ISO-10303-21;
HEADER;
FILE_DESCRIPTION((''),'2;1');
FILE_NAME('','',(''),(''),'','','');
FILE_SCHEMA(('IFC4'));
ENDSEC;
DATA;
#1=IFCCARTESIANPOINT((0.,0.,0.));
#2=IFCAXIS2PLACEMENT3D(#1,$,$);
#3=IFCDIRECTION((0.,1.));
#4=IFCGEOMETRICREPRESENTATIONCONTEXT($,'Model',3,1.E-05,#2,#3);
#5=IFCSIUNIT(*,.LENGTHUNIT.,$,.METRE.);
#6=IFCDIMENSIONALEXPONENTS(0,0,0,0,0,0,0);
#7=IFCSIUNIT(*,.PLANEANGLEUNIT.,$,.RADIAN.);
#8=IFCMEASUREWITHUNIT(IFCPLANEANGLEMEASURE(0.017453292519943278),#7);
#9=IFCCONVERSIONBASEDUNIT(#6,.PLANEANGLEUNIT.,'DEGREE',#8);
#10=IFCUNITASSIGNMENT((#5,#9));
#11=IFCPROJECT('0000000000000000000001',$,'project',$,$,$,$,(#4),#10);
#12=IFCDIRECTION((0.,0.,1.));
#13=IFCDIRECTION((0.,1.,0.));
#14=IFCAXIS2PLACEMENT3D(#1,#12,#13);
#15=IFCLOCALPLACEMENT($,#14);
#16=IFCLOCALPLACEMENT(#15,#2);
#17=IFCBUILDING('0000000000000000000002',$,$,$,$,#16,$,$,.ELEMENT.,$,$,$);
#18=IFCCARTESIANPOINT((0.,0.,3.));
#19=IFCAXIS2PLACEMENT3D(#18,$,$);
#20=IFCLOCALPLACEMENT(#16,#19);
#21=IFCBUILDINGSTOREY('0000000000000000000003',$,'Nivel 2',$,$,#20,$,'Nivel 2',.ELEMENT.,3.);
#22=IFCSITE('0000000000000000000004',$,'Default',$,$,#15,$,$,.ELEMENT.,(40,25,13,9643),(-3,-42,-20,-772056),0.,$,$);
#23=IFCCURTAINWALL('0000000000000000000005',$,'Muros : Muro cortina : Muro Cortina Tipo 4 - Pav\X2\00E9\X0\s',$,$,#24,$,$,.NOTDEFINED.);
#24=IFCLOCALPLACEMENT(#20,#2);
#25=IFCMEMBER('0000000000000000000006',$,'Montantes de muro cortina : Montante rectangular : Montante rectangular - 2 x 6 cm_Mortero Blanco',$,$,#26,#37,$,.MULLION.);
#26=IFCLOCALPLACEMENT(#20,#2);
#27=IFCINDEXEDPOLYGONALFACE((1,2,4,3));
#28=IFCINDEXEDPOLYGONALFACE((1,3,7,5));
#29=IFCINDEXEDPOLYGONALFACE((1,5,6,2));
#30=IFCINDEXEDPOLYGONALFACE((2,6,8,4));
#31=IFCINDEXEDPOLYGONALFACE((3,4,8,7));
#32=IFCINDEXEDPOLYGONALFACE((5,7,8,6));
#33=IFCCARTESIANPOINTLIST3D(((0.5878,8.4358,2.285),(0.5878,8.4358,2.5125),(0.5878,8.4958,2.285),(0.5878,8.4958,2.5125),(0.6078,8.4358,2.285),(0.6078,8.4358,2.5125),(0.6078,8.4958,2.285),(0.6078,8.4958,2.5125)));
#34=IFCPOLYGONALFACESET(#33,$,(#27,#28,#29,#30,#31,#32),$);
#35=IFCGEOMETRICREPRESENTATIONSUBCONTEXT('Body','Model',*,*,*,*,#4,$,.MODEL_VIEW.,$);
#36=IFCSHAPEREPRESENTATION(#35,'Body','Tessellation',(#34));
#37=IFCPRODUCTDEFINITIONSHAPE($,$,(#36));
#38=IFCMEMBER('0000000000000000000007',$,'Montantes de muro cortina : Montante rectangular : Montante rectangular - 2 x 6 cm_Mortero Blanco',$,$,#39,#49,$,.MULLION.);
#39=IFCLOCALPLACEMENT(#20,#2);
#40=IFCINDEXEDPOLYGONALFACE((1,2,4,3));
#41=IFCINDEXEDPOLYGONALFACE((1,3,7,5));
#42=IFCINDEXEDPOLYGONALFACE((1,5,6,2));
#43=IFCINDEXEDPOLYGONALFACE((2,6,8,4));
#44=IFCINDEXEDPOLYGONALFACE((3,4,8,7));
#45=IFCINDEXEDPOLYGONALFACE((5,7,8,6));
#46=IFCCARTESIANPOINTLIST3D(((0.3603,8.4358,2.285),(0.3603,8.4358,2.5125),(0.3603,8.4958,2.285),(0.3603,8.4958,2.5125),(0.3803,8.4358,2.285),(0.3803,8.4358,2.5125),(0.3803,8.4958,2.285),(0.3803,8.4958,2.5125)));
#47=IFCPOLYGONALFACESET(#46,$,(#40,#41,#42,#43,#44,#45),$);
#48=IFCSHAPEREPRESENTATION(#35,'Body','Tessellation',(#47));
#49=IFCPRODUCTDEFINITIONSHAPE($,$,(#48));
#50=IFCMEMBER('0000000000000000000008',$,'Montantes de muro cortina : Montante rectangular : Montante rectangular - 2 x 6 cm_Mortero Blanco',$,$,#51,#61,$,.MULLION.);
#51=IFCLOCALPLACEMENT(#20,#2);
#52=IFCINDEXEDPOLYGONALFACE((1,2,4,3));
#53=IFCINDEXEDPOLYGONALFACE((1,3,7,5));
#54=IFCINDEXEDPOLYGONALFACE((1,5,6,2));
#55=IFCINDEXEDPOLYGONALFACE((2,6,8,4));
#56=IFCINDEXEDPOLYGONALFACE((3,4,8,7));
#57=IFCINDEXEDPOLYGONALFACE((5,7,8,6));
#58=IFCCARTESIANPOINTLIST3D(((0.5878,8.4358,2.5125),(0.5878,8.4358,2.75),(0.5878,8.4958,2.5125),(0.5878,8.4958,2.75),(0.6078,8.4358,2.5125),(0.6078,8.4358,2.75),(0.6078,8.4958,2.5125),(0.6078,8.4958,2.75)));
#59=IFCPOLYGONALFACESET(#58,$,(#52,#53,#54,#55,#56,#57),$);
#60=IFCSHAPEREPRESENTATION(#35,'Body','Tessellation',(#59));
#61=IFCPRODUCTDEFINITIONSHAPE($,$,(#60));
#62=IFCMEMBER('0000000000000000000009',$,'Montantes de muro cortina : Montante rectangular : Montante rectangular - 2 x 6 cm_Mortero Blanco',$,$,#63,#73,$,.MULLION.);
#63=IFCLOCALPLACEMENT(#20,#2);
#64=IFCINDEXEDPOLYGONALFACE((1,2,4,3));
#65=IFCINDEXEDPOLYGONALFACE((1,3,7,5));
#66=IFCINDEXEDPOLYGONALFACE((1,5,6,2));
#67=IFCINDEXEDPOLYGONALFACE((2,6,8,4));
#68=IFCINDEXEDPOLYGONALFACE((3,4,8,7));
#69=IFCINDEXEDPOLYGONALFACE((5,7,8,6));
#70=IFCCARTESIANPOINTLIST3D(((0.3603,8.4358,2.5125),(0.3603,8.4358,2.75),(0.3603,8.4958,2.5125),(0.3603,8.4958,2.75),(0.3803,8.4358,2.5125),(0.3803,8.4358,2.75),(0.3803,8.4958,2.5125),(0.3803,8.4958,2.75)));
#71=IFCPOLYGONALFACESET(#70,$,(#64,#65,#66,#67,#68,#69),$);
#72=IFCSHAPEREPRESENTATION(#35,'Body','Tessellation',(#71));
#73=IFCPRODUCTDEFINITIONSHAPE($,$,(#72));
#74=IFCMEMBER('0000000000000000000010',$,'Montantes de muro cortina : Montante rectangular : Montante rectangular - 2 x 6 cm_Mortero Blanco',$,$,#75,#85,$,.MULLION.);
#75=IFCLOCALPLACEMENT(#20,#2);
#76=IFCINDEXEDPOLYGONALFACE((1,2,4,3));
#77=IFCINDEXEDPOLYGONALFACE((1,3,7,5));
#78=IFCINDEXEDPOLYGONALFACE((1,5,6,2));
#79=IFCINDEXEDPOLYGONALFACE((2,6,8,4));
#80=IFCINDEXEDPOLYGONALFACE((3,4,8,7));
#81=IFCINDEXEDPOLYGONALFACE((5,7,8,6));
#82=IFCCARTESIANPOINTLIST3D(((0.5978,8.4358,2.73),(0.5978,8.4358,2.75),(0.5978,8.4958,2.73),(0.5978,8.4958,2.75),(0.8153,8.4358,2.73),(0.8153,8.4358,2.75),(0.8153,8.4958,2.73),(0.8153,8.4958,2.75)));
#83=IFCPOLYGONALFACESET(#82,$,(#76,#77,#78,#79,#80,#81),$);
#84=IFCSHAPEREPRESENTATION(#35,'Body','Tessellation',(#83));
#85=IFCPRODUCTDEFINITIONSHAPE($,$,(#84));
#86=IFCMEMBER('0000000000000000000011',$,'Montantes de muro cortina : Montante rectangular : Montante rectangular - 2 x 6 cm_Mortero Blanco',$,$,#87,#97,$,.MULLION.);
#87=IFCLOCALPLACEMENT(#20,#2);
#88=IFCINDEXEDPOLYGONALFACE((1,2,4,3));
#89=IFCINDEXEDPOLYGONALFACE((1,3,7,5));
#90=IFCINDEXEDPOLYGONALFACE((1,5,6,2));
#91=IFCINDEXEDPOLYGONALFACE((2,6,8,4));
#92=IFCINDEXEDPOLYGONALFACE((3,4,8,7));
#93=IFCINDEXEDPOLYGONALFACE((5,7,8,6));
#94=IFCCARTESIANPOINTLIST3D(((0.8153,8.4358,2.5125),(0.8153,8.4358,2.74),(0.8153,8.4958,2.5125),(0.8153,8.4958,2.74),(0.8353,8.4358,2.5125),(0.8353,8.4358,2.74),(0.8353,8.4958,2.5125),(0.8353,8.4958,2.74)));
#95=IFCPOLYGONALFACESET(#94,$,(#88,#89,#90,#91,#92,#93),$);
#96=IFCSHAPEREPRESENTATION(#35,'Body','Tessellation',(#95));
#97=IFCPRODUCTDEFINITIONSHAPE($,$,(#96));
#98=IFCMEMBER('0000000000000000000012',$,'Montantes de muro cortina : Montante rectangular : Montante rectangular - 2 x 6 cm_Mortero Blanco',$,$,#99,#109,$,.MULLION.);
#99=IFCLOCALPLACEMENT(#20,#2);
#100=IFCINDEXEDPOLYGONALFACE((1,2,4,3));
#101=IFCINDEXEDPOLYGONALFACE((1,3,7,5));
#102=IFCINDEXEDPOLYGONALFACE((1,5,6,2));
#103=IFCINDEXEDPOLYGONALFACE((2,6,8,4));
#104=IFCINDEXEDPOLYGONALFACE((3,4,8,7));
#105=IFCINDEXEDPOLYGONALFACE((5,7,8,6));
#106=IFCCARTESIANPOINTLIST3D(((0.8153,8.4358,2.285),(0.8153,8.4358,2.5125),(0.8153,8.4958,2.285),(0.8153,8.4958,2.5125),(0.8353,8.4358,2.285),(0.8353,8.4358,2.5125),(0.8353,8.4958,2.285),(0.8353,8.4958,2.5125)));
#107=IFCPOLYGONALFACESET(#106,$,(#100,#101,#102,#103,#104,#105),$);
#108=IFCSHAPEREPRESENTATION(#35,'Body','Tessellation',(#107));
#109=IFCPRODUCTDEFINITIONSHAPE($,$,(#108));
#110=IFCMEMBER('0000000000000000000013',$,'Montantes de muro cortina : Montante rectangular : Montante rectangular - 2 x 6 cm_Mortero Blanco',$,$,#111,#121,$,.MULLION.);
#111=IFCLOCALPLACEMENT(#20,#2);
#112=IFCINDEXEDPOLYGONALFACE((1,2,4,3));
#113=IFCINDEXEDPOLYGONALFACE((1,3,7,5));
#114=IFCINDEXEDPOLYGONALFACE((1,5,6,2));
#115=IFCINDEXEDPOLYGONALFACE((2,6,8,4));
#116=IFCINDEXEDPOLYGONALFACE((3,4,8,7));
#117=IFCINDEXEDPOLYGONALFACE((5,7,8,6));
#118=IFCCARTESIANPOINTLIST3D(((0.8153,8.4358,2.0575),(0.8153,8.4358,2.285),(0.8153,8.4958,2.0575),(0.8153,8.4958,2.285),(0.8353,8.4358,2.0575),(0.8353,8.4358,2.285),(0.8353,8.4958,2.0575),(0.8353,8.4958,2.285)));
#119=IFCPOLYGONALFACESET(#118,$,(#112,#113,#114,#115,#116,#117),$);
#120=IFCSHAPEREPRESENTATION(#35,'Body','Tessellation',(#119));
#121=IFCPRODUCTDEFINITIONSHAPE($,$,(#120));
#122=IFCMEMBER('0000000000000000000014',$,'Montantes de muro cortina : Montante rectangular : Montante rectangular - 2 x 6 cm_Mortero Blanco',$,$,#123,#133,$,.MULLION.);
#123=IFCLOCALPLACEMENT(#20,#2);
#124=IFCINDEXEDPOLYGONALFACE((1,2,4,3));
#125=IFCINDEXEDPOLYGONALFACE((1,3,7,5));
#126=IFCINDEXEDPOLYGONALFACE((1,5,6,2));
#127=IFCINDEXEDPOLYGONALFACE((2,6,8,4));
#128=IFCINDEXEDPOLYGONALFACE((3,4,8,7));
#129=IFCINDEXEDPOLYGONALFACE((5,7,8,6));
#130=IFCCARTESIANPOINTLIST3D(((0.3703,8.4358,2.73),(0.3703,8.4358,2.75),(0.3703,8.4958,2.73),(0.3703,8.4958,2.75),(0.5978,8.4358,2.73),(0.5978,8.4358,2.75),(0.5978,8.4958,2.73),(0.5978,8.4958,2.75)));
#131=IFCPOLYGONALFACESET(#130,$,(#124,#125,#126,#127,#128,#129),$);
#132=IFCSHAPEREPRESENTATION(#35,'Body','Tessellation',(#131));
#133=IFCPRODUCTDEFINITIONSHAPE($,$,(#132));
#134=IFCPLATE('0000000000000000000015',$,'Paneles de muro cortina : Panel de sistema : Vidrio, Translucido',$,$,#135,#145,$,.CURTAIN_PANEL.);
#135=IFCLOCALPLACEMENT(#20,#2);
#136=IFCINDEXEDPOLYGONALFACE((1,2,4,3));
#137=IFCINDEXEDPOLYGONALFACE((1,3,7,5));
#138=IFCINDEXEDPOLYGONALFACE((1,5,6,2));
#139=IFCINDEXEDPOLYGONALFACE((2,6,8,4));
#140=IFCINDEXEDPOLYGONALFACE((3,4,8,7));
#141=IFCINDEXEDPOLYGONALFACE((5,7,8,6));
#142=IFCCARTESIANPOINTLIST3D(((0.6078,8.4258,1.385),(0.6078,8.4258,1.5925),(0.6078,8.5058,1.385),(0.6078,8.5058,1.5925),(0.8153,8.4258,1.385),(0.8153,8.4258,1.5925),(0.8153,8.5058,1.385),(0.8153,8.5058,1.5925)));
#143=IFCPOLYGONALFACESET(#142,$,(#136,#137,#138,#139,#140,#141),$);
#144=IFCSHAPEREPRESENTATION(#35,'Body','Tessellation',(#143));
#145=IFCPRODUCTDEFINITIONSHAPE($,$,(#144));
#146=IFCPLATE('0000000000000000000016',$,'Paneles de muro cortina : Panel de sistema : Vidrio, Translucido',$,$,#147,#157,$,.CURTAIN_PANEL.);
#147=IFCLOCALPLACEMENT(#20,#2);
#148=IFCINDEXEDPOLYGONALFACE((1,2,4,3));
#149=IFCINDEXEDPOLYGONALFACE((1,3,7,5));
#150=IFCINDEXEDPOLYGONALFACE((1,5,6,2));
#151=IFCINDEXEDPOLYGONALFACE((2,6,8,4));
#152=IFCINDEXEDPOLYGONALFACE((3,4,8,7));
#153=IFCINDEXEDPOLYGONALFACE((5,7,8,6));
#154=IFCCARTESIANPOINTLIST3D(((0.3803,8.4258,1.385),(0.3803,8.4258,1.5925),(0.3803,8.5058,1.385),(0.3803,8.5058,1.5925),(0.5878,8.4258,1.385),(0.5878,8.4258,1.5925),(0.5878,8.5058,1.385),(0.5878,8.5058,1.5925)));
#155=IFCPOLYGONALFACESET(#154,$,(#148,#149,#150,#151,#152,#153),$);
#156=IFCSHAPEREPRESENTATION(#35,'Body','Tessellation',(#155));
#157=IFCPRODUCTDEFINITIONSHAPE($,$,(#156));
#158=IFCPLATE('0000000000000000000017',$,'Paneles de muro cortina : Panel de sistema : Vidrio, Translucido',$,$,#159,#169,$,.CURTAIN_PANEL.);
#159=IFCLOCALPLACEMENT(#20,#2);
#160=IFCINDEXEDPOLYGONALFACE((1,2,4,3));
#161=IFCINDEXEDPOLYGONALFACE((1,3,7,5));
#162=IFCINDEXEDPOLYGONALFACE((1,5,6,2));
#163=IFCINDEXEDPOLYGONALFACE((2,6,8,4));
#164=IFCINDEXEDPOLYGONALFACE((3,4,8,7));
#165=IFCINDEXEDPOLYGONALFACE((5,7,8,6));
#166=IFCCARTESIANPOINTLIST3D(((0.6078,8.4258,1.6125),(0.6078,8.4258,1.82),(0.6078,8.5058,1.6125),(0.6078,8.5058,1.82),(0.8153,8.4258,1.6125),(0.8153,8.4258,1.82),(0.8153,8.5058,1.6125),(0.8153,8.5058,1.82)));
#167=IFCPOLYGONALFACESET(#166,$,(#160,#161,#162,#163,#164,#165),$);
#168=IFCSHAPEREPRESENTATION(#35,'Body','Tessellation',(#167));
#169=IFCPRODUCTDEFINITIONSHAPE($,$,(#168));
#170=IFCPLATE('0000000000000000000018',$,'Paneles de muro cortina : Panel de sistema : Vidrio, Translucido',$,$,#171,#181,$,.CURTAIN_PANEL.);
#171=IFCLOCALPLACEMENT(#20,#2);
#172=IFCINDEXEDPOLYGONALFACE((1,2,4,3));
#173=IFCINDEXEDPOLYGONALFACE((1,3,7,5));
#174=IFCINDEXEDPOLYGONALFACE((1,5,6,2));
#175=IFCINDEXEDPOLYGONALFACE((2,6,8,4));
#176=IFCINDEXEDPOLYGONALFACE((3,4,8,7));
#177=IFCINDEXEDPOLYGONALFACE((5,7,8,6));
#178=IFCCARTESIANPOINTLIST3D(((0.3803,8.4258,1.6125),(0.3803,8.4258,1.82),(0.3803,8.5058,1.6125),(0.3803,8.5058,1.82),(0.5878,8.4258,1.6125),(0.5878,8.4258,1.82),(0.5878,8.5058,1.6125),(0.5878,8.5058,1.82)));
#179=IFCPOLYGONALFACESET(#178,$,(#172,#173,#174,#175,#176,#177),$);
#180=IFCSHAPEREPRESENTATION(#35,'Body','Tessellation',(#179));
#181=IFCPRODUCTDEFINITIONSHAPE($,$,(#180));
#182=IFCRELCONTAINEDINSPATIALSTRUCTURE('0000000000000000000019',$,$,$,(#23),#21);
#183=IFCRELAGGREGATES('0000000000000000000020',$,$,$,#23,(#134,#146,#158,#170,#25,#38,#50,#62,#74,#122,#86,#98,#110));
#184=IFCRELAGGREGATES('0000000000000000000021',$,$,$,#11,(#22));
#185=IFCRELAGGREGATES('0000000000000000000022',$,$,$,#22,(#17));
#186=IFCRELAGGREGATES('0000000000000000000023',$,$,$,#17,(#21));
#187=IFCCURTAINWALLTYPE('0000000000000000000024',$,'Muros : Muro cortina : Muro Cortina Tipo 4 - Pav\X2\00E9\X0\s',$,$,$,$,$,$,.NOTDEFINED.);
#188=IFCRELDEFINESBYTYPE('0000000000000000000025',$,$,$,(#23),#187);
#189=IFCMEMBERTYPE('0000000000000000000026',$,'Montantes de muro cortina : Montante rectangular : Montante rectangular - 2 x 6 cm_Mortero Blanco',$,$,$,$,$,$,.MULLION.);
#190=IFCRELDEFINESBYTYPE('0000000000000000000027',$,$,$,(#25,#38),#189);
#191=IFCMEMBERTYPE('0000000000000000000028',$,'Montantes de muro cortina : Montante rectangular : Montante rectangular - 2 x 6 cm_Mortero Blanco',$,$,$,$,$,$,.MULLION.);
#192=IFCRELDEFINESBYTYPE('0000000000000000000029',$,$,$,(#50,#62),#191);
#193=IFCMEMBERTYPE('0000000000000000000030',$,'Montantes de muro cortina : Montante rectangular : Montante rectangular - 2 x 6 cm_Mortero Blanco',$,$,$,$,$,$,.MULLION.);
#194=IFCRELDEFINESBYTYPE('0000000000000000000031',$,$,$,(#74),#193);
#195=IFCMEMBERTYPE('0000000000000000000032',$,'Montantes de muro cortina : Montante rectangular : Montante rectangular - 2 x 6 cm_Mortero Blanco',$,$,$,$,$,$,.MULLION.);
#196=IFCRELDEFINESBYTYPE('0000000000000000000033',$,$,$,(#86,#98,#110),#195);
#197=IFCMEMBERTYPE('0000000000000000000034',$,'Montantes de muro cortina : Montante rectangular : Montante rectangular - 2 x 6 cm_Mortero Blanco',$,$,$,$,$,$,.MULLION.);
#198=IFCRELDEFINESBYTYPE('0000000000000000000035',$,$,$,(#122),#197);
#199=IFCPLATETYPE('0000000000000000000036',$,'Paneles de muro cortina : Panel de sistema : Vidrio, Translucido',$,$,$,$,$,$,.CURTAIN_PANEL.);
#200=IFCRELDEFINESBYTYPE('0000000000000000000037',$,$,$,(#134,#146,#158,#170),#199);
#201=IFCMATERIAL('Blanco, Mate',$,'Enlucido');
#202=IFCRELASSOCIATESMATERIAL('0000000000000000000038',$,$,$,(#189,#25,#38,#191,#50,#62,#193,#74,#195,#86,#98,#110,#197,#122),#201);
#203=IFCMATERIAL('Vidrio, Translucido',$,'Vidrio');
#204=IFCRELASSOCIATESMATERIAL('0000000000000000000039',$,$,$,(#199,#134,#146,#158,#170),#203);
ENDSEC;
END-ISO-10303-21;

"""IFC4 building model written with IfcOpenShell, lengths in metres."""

from ifc_helpers import new_model, entity, si_unit, converted_unit, direction, frame, origin, place, context, subcontext, project, spatial, indexed_curve, outline, extrude, source, transform, mapped, material, type_object, type_shapes, element, aggregate, save


model = new_model("IFC4")

# Units and contexts
model_context = context("Model", 3, precision=1e-05, world=origin(), true_north=direction((0.0, 1.0)))
body_context = subcontext(model_context, "Body", "Model", "MODEL_VIEW")
ifc_project = project(units=[si_unit("LENGTHUNIT", "METRE"), converted_unit("PLANEANGLEUNIT", "DEGREE", entity("IfcPlaneAngleMeasure", 0.017453292519943278), si_unit("PLANEANGLEUNIT", "RADIAN"), dimensions=[0, 0, 0, 0, 0, 0, 0])], contexts=[model_context])

# Site, building, storey
site_placement = place(None, frame((0.0, 0.0, 0.0), z_axis=(0.0, 0.0, 1.0), x_axis=(0.0, 1.0, 0.0)))
site = spatial("IfcSite", under=ifc_project, at=site_placement, Name="Default", CompositionType="ELEMENT", RefLatitude=(40, 25, 13, 9643), RefLongitude=(-3, -42, -20, -772056), RefElevation=0.0)
building_placement = place(site_placement, origin())
building = spatial("IfcBuilding", under=site, at=building_placement, CompositionType="ELEMENT")
storey_placement = place(building_placement, frame((0.0, 0.0, 3.0)))
storey = spatial("IfcBuildingStorey", under=building, at=storey_placement, Name="Nivel 2", LongName="Nivel 2", CompositionType="ELEMENT", Elevation=3.0)

# Curtain wall, members, plates
curtain_wall_type = type_object("IfcCurtainWallType", Name="Muros : Muro cortina : Muro Cortina Tipo 4 - Pavés", PredefinedType="NOTDEFINED")
curtain_wall_placement = place(storey_placement, frame((0.0, 0.0, -3.0)))
curtain_wall = element("IfcCurtainWall", 1, at=curtain_wall_placement, inside=storey, type_object=curtain_wall_type, Name="Muros : Muro cortina : Muro Cortina Tipo 4 - Pavés", PredefinedType="NOTDEFINED")
ifc_material_1 = material(Name="Blanco, Mate", Category="Enlucido")
member_type_1 = type_object("IfcMemberType", Name="Montantes de muro cortina : Montante rectangular : Montante rectangular - 2 x 6 cm_Mortero Blanco", PredefinedType="MULLION", material=ifc_material_1)
shared_shape_1 = source(origin(), body_context, "Body", "SweptSolid", [
    extrude(outline(indexed_curve([(-0.01, -0.03), (0.01, -0.03), (0.01, 0.03), (-0.01, 0.03), (-0.01, -0.03)], self_intersect=False)), frame((0.0, 0.0, -0.2275), z_axis=(0.0, 0.0, 1.0), x_axis=(-1.0, 0.0, 0.0)), (0.0, 0.0, 1.0), 0.2275),
])
type_shapes(member_type_1, [shared_shape_1])
member_1_placement = place(curtain_wall_placement, frame((0.5978, 8.4658, 5.285), z_axis=(0.0, 0.0, -1.0), x_axis=(-1.0, 0.0, 0.0)))
member_1 = element("IfcMember", 2, at=member_1_placement, type_object=member_type_1, material=ifc_material_1, Name="Montantes de muro cortina : Montante rectangular : Montante rectangular - 2 x 6 cm_Mortero Blanco", PredefinedType="MULLION", context=body_context, shape_type="MappedRepresentation", body=[
    mapped(shared_shape_1, transform((0.0, 0.0, 0.0), scale=1.0)),
])
member_2_placement = place(curtain_wall_placement, frame((0.3703, 8.4658, 5.285), z_axis=(0.0, 0.0, -1.0), x_axis=(-1.0, 0.0, 0.0)))
member_2 = element("IfcMember", 3, at=member_2_placement, type_object=member_type_1, material=ifc_material_1, Name="Montantes de muro cortina : Montante rectangular : Montante rectangular - 2 x 6 cm_Mortero Blanco", PredefinedType="MULLION", context=body_context, shape_type="MappedRepresentation", body=[
    mapped(shared_shape_1, transform((0.0, 0.0, 0.0), scale=1.0)),
])
member_type_2 = type_object("IfcMemberType", Name="Montantes de muro cortina : Montante rectangular : Montante rectangular - 2 x 6 cm_Mortero Blanco", PredefinedType="MULLION", material=ifc_material_1)
shared_shape_2 = source(origin(), body_context, "Body", "SweptSolid", [
    extrude(outline(indexed_curve([(-0.01, -0.03), (0.01, -0.03), (0.01, 0.03), (-0.01, 0.03), (-0.01, -0.03)], self_intersect=False)), frame((0.0, 0.0, -0.2375), z_axis=(0.0, 0.0, 1.0), x_axis=(-1.0, 0.0, 0.0)), (0.0, 0.0, 1.0), 0.2375),
])
type_shapes(member_type_2, [shared_shape_2])
member_3_placement = place(curtain_wall_placement, frame((0.5978, 8.4658, 5.5125), z_axis=(0.0, 0.0, -1.0), x_axis=(-1.0, 0.0, 0.0)))
member_3 = element("IfcMember", 4, at=member_3_placement, type_object=member_type_2, material=ifc_material_1, Name="Montantes de muro cortina : Montante rectangular : Montante rectangular - 2 x 6 cm_Mortero Blanco", PredefinedType="MULLION", context=body_context, shape_type="MappedRepresentation", body=[
    mapped(shared_shape_2, transform((0.0, 0.0, 0.0), scale=1.0)),
])
member_4_placement = place(curtain_wall_placement, frame((0.3703, 8.4658, 5.5125), z_axis=(0.0, 0.0, -1.0), x_axis=(-1.0, 0.0, 0.0)))
member_4 = element("IfcMember", 5, at=member_4_placement, type_object=member_type_2, material=ifc_material_1, Name="Montantes de muro cortina : Montante rectangular : Montante rectangular - 2 x 6 cm_Mortero Blanco", PredefinedType="MULLION", context=body_context, shape_type="MappedRepresentation", body=[
    mapped(shared_shape_2, transform((0.0, 0.0, 0.0), scale=1.0)),
])
member_type_3 = type_object("IfcMemberType", Name="Montantes de muro cortina : Montante rectangular : Montante rectangular - 2 x 6 cm_Mortero Blanco", PredefinedType="MULLION", material=ifc_material_1)
shared_shape_3 = source(origin(), body_context, "Body", "SweptSolid", [
    extrude(outline(indexed_curve([(-0.01, -0.03), (0.01, -0.03), (0.01, 0.03), (-0.01, 0.03), (-0.01, -0.03)], self_intersect=False)), frame((-0.01, 0.0, -0.2175), z_axis=(0.0, 0.0, 1.0), x_axis=(-1.0, 0.0, 0.0)), (0.0, 0.0, 1.0), 0.2175),
])
type_shapes(member_type_3, [shared_shape_3])
member_5_placement = place(curtain_wall_placement, frame((0.5978, 8.4658, 5.75), z_axis=(-1.0, 0.0, 0.0), x_axis=(0.0, 0.0, 1.0)))
member_5 = element("IfcMember", 6, at=member_5_placement, type_object=member_type_3, material=ifc_material_1, Name="Montantes de muro cortina : Montante rectangular : Montante rectangular - 2 x 6 cm_Mortero Blanco", PredefinedType="MULLION", context=body_context, shape_type="MappedRepresentation", body=[
    mapped(shared_shape_3, transform((0.0, 0.0, 0.0), scale=1.0)),
])
member_type_4 = type_object("IfcMemberType", Name="Montantes de muro cortina : Montante rectangular : Montante rectangular - 2 x 6 cm_Mortero Blanco", PredefinedType="MULLION", material=ifc_material_1)
shared_shape_4 = source(origin(), body_context, "Body", "SweptSolid", [
    extrude(outline(indexed_curve([(-0.01, -0.03), (0.01, -0.03), (0.01, 0.03), (-0.01, 0.03), (-0.01, -0.03)], self_intersect=False)), frame((-0.01, 0.0, -0.2275), z_axis=(0.0, 0.0, 1.0), x_axis=(-1.0, 0.0, 0.0)), (0.0, 0.0, 1.0), 0.2275),
])
type_shapes(member_type_4, [shared_shape_4])
member_6_placement = place(curtain_wall_placement, frame((0.8353, 8.4658, 5.74)))
member_6 = element("IfcMember", 7, at=member_6_placement, type_object=member_type_4, material=ifc_material_1, Name="Montantes de muro cortina : Montante rectangular : Montante rectangular - 2 x 6 cm_Mortero Blanco", PredefinedType="MULLION", context=body_context, shape_type="MappedRepresentation", body=[
    mapped(shared_shape_4, transform((0.0, 0.0, 0.0), scale=1.0)),
])
member_7_placement = place(curtain_wall_placement, frame((0.8353, 8.4658, 5.5125)))
member_7 = element("IfcMember", 8, at=member_7_placement, type_object=member_type_4, material=ifc_material_1, Name="Montantes de muro cortina : Montante rectangular : Montante rectangular - 2 x 6 cm_Mortero Blanco", PredefinedType="MULLION", context=body_context, shape_type="MappedRepresentation", body=[
    mapped(shared_shape_4, transform((0.0, 0.0, 0.0), scale=1.0)),
])
member_8_placement = place(curtain_wall_placement, frame((0.8353, 8.4658, 5.285)))
member_8 = element("IfcMember", 9, at=member_8_placement, type_object=member_type_4, material=ifc_material_1, Name="Montantes de muro cortina : Montante rectangular : Montante rectangular - 2 x 6 cm_Mortero Blanco", PredefinedType="MULLION", context=body_context, shape_type="MappedRepresentation", body=[
    mapped(shared_shape_4, transform((0.0, 0.0, 0.0), scale=1.0)),
])
member_type_5 = type_object("IfcMemberType", Name="Montantes de muro cortina : Montante rectangular : Montante rectangular - 2 x 6 cm_Mortero Blanco", PredefinedType="MULLION", material=ifc_material_1)
shared_shape_5 = source(origin(), body_context, "Body", "SweptSolid", [
    extrude(outline(indexed_curve([(-0.01, -0.03), (0.01, -0.03), (0.01, 0.03), (-0.01, 0.03), (-0.01, -0.03)], self_intersect=False)), frame((-0.01, 0.0, -0.2275), z_axis=(0.0, 0.0, 1.0), x_axis=(-1.0, 0.0, 0.0)), (0.0, 0.0, 1.0), 0.2275),
])
type_shapes(member_type_5, [shared_shape_5])
member_9_placement = place(curtain_wall_placement, frame((0.3703, 8.4658, 5.75), z_axis=(-1.0, 0.0, 0.0), x_axis=(0.0, 0.0, 1.0)))
member_9 = element("IfcMember", 10, at=member_9_placement, type_object=member_type_5, material=ifc_material_1, Name="Montantes de muro cortina : Montante rectangular : Montante rectangular - 2 x 6 cm_Mortero Blanco", PredefinedType="MULLION", context=body_context, shape_type="MappedRepresentation", body=[
    mapped(shared_shape_5, transform((0.0, 0.0, 0.0), scale=1.0)),
])
ifc_material_2 = material(Name="Vidrio, Translucido", Category="Vidrio")
plate_type = type_object("IfcPlateType", Name="Paneles de muro cortina : Panel de sistema : Vidrio, Translucido", PredefinedType="CURTAIN_PANEL", material=ifc_material_2)
shared_shape_6 = source(origin(), body_context, "Body", "SweptSolid", [
    extrude(outline(indexed_curve([(-0.04, -0.1038), (0.04, -0.1038), (0.04, 0.1038), (-0.04, 0.1038), (-0.04, -0.1038)], self_intersect=False)), frame((0.0, 0.0, 0.0), z_axis=(0.0, 0.0, 1.0), x_axis=(0.0, 1.0, 0.0)), (0.0, 0.0, 1.0), 0.2075),
])
type_shapes(plate_type, [shared_shape_6])
plate_1_placement = place(curtain_wall_placement, frame((0.7115, 8.4658, 4.385), z_axis=(0.0, 0.0, 1.0), x_axis=(-1.0, 0.0, 0.0)))
plate_1 = element("IfcPlate", 11, at=plate_1_placement, type_object=plate_type, material=ifc_material_2, Name="Paneles de muro cortina : Panel de sistema : Vidrio, Translucido", PredefinedType="CURTAIN_PANEL", context=body_context, shape_type="MappedRepresentation", body=[
    mapped(shared_shape_6, transform((0.0, 0.0, 0.0), scale=1.0)),
])
plate_2_placement = place(curtain_wall_placement, frame((0.484, 8.4658, 4.385), z_axis=(0.0, 0.0, 1.0), x_axis=(-1.0, 0.0, 0.0)))
plate_2 = element("IfcPlate", 12, at=plate_2_placement, type_object=plate_type, material=ifc_material_2, Name="Paneles de muro cortina : Panel de sistema : Vidrio, Translucido", PredefinedType="CURTAIN_PANEL", context=body_context, shape_type="MappedRepresentation", body=[
    mapped(shared_shape_6, transform((0.0, 0.0, 0.0), scale=1.0)),
])
plate_3_placement = place(curtain_wall_placement, frame((0.7115, 8.4658, 4.6125), z_axis=(0.0, 0.0, 1.0), x_axis=(-1.0, 0.0, 0.0)))
plate_3 = element("IfcPlate", 13, at=plate_3_placement, type_object=plate_type, material=ifc_material_2, Name="Paneles de muro cortina : Panel de sistema : Vidrio, Translucido", PredefinedType="CURTAIN_PANEL", context=body_context, shape_type="MappedRepresentation", body=[
    mapped(shared_shape_6, transform((0.0, 0.0, 0.0), scale=1.0)),
])
plate_4_placement = place(curtain_wall_placement, frame((0.484, 8.4658, 4.6125), z_axis=(0.0, 0.0, 1.0), x_axis=(-1.0, 0.0, 0.0)))
plate_4 = element("IfcPlate", 14, at=plate_4_placement, type_object=plate_type, material=ifc_material_2, Name="Paneles de muro cortina : Panel de sistema : Vidrio, Translucido", PredefinedType="CURTAIN_PANEL", context=body_context, shape_type="MappedRepresentation", body=[
    mapped(shared_shape_6, transform((0.0, 0.0, 0.0), scale=1.0)),
])
aggregate(curtain_wall, [plate_1, plate_2, plate_3, plate_4, member_1, member_2, member_3, member_4, member_5, member_9, member_6, member_7, member_8])

save(model, "model.ifc")
